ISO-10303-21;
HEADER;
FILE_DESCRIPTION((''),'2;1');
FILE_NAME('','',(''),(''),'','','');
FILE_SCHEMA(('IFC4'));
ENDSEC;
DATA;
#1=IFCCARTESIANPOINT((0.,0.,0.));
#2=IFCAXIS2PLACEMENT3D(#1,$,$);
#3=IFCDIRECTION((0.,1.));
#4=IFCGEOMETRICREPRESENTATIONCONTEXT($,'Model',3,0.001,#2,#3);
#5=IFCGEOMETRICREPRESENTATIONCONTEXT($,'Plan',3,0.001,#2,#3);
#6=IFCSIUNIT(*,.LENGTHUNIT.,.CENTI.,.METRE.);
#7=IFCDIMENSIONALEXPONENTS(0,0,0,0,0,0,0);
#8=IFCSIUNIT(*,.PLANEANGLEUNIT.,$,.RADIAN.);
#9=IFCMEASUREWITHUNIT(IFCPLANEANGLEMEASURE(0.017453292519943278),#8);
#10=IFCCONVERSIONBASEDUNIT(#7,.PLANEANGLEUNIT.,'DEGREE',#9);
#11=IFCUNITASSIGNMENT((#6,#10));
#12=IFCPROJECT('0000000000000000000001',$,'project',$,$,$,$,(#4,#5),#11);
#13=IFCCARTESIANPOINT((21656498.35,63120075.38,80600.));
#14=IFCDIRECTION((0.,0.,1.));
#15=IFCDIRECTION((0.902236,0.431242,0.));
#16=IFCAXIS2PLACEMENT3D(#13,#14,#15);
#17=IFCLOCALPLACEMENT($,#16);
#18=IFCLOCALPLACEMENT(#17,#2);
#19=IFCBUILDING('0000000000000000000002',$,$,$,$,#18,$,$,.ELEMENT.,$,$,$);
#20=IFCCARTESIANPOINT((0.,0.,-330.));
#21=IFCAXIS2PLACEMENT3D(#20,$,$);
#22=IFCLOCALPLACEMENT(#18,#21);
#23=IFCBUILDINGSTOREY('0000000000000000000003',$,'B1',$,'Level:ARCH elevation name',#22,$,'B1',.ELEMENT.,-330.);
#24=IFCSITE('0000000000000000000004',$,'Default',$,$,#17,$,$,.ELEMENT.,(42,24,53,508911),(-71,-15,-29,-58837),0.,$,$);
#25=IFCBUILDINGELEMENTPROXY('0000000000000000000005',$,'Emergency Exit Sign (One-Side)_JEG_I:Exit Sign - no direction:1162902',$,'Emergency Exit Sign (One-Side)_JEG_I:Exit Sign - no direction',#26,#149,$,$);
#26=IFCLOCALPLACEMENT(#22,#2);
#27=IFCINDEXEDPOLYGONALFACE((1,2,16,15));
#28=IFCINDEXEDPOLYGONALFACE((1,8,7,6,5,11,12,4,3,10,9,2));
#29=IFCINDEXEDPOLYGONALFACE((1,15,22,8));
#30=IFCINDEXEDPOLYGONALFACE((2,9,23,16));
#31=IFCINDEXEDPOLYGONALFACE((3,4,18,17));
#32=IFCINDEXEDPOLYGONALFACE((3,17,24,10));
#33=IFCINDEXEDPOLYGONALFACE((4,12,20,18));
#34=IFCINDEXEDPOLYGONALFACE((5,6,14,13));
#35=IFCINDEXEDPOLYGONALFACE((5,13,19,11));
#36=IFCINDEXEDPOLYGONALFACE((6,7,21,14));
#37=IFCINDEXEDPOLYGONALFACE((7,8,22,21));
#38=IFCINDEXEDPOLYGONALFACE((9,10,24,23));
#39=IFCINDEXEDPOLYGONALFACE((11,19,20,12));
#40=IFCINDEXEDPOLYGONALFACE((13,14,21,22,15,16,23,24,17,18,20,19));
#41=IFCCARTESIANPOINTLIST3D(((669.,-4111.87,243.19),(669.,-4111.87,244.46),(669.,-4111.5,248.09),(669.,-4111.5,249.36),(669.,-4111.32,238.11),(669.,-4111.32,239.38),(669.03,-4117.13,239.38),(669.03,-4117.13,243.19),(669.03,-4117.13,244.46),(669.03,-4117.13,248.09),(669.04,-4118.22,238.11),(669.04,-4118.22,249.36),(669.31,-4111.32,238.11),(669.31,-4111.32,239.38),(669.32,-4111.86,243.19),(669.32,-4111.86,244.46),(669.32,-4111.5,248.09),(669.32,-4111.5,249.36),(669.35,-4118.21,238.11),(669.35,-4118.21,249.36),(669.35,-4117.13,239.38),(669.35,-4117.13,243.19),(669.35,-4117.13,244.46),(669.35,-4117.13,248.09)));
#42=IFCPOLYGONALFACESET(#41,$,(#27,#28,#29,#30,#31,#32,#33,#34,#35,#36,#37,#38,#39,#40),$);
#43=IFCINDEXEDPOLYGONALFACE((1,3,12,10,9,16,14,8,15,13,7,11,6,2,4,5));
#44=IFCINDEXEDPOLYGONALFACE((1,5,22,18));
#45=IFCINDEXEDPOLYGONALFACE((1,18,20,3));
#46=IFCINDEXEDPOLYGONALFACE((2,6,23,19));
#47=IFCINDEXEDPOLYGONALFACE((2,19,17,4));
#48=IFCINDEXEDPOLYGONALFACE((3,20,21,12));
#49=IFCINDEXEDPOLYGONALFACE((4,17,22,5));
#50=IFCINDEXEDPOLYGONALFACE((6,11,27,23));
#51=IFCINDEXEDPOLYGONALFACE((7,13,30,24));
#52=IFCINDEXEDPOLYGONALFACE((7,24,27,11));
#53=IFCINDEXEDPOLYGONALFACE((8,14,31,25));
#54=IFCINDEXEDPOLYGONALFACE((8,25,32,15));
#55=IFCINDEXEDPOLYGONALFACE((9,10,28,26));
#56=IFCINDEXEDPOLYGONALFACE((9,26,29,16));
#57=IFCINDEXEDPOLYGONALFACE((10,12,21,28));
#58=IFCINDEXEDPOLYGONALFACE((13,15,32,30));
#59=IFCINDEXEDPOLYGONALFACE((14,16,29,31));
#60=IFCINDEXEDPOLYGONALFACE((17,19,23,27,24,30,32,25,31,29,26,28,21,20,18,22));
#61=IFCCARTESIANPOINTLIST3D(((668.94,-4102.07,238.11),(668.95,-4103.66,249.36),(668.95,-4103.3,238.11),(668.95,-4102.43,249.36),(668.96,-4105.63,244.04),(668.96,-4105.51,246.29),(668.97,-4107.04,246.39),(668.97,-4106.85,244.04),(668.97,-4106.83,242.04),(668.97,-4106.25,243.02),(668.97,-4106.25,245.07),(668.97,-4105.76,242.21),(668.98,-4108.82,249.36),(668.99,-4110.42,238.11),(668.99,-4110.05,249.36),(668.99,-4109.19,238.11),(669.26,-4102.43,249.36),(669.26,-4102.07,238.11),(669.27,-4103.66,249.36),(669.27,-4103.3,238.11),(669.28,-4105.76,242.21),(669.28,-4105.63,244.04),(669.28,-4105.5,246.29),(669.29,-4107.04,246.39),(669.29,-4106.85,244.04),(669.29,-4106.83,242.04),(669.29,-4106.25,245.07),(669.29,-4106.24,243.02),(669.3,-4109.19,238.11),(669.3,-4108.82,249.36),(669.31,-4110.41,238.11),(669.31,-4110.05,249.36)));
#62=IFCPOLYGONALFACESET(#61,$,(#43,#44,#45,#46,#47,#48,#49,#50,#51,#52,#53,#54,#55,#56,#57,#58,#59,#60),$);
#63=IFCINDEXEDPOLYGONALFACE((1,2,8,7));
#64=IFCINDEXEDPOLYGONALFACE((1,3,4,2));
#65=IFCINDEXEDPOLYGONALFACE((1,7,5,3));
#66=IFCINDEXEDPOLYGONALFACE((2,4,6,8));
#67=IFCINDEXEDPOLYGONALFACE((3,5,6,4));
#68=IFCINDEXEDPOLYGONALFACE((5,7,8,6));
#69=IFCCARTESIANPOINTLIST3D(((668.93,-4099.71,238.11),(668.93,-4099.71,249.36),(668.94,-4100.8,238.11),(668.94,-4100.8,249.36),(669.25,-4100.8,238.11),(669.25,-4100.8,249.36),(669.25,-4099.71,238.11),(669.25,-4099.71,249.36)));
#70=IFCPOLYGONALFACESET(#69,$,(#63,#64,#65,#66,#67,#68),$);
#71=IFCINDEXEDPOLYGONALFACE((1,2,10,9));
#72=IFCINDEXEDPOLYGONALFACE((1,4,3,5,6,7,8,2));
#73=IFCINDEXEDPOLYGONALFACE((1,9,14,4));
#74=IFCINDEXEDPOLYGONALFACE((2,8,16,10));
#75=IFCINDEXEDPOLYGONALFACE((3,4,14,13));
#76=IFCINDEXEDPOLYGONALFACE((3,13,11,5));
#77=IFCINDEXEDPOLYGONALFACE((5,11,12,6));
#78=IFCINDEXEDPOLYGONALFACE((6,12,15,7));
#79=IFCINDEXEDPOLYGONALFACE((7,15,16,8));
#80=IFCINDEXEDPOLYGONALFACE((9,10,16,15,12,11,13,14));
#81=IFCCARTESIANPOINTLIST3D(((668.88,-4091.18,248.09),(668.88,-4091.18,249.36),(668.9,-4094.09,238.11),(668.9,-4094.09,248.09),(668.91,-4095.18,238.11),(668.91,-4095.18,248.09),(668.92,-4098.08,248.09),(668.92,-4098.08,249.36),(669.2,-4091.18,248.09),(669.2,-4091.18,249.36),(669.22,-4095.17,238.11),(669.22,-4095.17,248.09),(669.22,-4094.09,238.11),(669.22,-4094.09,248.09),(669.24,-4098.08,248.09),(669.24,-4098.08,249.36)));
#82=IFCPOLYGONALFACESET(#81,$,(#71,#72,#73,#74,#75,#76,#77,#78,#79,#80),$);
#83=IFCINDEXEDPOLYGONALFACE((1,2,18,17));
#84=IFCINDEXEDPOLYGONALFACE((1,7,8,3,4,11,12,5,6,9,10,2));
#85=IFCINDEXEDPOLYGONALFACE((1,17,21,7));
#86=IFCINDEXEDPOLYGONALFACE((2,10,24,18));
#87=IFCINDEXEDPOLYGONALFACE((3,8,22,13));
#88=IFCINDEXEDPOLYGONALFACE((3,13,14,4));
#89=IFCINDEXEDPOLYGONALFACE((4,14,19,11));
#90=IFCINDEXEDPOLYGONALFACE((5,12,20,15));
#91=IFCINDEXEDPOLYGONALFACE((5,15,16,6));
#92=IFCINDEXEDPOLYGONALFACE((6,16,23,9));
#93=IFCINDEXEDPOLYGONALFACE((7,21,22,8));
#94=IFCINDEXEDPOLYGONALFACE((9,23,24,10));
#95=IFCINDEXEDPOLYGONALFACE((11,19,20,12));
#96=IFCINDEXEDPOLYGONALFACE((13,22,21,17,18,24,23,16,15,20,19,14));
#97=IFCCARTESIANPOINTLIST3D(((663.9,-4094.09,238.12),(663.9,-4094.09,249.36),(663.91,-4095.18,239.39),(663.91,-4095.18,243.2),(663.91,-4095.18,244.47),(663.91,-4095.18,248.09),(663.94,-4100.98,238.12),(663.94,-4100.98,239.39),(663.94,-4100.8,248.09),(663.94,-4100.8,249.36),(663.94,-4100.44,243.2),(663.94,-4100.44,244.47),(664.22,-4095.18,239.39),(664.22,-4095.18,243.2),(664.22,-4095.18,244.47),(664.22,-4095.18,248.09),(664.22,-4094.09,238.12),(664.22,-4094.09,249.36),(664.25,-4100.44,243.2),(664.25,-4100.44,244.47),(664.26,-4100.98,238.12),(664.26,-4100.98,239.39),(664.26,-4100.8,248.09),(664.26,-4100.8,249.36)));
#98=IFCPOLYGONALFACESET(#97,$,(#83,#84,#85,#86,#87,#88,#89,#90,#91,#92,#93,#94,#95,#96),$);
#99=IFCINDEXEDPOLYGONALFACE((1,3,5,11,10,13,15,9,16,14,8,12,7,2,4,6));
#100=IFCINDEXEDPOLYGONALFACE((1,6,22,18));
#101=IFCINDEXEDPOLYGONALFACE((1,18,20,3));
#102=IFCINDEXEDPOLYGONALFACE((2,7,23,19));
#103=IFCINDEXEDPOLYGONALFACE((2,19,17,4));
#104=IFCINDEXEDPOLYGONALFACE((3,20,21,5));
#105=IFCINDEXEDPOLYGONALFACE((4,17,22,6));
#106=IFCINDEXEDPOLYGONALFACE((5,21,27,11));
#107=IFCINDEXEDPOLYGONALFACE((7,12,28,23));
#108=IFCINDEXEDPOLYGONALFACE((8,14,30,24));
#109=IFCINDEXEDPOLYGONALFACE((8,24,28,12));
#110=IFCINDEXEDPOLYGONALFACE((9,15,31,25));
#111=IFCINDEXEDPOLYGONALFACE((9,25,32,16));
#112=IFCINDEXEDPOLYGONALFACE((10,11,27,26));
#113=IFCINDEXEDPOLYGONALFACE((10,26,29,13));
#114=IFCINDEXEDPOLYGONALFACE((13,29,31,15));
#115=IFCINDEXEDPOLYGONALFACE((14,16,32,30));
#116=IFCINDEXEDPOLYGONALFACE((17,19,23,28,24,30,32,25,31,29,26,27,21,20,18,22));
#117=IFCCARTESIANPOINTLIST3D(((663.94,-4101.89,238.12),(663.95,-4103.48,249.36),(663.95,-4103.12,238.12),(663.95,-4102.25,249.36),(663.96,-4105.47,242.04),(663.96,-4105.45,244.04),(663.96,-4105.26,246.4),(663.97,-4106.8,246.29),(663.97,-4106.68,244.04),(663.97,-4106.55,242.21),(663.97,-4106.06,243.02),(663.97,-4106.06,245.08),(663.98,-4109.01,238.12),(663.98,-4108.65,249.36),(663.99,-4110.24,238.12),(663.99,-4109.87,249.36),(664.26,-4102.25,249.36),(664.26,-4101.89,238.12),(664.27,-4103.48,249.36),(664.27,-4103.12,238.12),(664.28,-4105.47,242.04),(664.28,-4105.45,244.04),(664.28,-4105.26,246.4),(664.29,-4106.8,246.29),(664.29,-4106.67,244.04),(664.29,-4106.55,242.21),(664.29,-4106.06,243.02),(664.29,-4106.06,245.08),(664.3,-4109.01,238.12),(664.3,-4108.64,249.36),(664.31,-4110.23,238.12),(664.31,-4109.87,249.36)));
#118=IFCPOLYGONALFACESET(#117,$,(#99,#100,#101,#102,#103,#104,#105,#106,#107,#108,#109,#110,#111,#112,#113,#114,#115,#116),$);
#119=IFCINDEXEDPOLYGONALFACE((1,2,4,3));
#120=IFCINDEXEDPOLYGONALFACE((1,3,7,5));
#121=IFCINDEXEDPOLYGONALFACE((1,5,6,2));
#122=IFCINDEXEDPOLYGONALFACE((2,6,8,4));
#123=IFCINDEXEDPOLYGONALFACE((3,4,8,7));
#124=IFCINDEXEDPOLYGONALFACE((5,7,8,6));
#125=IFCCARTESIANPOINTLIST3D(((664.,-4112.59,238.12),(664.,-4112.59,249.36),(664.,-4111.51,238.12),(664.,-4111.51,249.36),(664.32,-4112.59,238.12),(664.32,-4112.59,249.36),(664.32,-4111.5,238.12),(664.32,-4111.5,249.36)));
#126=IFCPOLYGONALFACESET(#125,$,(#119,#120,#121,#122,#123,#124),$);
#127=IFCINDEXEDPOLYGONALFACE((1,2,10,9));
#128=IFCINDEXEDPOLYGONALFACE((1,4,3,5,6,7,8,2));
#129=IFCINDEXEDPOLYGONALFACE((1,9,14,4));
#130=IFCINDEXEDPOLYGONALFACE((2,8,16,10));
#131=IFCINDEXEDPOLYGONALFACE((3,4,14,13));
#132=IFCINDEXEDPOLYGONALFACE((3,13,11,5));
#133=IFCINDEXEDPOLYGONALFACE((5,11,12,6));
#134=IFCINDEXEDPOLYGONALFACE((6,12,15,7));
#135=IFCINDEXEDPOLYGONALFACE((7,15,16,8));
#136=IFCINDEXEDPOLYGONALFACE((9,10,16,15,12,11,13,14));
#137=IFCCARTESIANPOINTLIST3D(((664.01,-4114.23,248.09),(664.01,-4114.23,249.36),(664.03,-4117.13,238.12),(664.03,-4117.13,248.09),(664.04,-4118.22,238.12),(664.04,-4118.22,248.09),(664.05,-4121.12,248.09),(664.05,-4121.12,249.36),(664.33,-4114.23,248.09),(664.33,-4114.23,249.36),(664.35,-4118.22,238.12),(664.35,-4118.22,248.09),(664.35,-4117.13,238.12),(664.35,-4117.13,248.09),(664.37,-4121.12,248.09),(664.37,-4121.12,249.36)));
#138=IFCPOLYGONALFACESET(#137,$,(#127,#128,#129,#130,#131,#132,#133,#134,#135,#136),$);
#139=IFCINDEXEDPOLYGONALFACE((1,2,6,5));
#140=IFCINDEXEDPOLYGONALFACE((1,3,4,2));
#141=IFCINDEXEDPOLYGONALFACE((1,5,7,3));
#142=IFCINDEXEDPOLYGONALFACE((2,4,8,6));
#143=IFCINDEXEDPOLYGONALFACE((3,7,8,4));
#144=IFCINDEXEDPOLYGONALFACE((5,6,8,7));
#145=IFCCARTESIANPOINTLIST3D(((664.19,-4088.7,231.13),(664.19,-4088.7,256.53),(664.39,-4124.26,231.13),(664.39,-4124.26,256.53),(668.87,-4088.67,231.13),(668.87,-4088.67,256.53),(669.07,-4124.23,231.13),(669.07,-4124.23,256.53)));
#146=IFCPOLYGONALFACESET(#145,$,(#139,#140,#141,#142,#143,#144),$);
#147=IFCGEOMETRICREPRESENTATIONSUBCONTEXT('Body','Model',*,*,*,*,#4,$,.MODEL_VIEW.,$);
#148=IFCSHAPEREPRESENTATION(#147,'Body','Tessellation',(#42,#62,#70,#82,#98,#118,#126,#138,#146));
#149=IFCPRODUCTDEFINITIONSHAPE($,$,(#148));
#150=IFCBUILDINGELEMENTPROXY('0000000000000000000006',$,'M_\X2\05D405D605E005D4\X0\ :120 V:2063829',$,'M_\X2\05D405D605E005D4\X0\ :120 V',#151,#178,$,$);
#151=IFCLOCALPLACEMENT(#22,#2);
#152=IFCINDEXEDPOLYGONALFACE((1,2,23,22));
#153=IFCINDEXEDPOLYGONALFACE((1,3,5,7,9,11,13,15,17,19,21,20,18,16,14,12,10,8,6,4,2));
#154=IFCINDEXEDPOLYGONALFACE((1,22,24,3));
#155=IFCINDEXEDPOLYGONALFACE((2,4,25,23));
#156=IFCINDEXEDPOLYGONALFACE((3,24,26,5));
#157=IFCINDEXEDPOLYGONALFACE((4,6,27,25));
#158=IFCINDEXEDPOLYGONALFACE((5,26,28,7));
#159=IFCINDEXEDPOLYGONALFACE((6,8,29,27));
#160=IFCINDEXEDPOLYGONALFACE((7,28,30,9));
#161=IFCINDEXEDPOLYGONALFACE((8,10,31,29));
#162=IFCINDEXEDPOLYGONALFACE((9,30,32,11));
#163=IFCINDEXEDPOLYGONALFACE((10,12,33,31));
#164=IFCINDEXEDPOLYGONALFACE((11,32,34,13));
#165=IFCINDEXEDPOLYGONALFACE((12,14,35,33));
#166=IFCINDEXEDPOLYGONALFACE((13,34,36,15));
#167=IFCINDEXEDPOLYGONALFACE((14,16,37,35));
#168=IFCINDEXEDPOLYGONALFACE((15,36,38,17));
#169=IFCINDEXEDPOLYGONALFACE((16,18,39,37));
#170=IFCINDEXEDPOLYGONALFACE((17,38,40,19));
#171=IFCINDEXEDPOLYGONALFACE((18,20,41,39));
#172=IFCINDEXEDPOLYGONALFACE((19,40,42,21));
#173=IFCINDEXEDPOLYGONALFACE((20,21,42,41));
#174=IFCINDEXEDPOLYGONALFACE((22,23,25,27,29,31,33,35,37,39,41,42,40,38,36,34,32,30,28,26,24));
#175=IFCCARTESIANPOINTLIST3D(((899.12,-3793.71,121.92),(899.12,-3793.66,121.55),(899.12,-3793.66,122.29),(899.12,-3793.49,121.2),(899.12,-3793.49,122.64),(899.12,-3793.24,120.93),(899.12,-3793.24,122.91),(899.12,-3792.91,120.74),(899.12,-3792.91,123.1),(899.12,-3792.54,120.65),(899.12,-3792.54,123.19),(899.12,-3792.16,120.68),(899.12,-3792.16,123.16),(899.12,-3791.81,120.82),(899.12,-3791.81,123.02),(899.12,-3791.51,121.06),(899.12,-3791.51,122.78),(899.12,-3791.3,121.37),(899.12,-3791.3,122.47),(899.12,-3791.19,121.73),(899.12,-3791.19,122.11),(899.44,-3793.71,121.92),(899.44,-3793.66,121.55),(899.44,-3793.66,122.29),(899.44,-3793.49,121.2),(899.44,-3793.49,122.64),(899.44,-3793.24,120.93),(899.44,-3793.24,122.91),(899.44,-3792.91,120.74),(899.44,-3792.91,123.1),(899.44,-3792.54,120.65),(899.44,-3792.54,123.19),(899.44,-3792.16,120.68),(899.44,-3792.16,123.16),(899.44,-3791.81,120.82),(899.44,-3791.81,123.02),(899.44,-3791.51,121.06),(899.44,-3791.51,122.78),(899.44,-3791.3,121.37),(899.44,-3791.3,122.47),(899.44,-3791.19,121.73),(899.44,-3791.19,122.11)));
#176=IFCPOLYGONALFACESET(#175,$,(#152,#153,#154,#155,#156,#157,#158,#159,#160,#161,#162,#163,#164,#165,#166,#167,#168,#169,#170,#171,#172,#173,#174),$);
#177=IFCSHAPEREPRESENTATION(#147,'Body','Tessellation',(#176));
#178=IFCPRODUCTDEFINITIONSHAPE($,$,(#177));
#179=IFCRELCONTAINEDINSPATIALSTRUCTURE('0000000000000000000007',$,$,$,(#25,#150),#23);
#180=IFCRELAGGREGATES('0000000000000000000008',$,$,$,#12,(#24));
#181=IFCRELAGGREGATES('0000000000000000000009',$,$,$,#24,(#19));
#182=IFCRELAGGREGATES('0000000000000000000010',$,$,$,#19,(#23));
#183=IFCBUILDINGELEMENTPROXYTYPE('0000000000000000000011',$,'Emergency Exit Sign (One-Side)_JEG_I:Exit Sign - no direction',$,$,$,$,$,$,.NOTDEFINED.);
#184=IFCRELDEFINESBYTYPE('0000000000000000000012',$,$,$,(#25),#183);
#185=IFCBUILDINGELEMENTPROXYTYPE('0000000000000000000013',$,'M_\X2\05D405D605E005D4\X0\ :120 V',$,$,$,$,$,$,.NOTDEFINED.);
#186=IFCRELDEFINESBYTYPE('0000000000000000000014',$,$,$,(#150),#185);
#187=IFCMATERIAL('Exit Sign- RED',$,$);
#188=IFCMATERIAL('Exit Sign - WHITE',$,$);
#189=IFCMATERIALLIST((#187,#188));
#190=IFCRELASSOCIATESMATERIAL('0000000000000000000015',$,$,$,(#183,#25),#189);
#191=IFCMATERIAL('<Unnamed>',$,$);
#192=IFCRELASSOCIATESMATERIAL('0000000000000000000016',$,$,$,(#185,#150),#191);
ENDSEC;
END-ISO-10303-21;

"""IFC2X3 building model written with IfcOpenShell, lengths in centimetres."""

from ifc_helpers import new_model, entity, si_unit, converted_unit, direction, frame, frame_2d, origin, origin_2d_with_axis, place, context, subcontext, project, spatial, polyline, rectangle, circle, outline, extrude, source, transform, mapped, material, material_list, type_object, type_shapes, element, save


model = new_model("IFC2X3")

# Units and contexts
model_context = context("Model", 3, precision=0.001, world=origin(), true_north=direction((0.0, 1.0)))
plan_context = context("Plan", 3, precision=0.001, world=origin(), true_north=direction((0.0, 1.0)))
body_context = subcontext(model_context, "Body", "Model", "MODEL_VIEW")
ifc_project = project(units=[si_unit("LENGTHUNIT", "METRE", prefix="CENTI"), converted_unit("PLANEANGLEUNIT", "DEGREE", entity("IfcPlaneAngleMeasure", 0.017453292519943278), si_unit("PLANEANGLEUNIT", "RADIAN"), dimensions=[0, 0, 0, 0, 0, 0, 0])], contexts=[model_context, plan_context])

# Site, building, storey
site_placement = place(None, frame((21656498.35, 63120075.38, 80600.0), z_axis=(0.0, 0.0, 1.0), x_axis=(0.902236, 0.431242, 0.0)))
site = spatial("IfcSite", under=ifc_project, at=site_placement, Name="Default", CompositionType="ELEMENT", RefLatitude=(42, 24, 53, 508911), RefLongitude=(-71, -15, -29, -58837), RefElevation=0.0)
building_placement = place(site_placement, origin())
building = spatial("IfcBuilding", under=site, at=building_placement, CompositionType="ELEMENT")
storey_placement = place(building_placement, frame((0.0, 0.0, -330.0)))
storey = spatial("IfcBuildingStorey", under=building, at=storey_placement, Name="B1", ObjectType="Level:ARCH elevation name", LongName="B1", CompositionType="ELEMENT", Elevation=-330.0)

# Building element proxies
ifc_material_1 = material(Name="Exit Sign- RED")
ifc_material_2 = material(Name="Exit Sign - WHITE")
ifc_material_list = material_list([ifc_material_1, ifc_material_2])
building_element_proxy_type_1 = type_object("IfcBuildingElementProxyType", Name="Emergency Exit Sign (One-Side)_JEG_I:Exit Sign - no direction", PredefinedType="NOTDEFINED", material=ifc_material_list)
shared_shape_1 = source(origin(), body_context, "Body", "SweptSolid", [
    extrude(outline(polyline([(-5.65, -3.69), (5.59, -3.69), (5.59, 3.02), (4.32, 3.02), (4.32, -2.6), (0.7, -2.6), (0.7, 2.66), (-0.57, 2.66), (-0.57, -2.6), (-4.38, -2.6), (-4.38, 3.21), (-5.65, 3.21), (-5.65, -3.69)])), frame((-8.08, -5.22, 12.64), z_axis=(0.0, 1.0, 0.0), x_axis=(0.0, 0.0, 1.0)), (0.0, 0.0, 1.0), 0.32),
    extrude(outline(polyline([(-7.14, 0.57), (-6.5, -0.49), (-1.93, -0.48), (-0.78, -0.48), (-1.23, -1.32), (-3.47, -5.53), (-2.84, -6.59), (0.41, -0.48), (6.62, -0.48), (5.99, 0.57), (2.4, 0.57), (0.98, 0.58), (1.7, 1.94), (3.32, 5.0), (2.69, 6.05), (-0.22, 0.57), (-7.14, 0.57)])), frame((0.2, -5.22, 12.81), z_axis=(0.0, -1.0, 0.0), x_axis=(0.515099, 0.0, 0.857131)), (0.0, 0.0, -1.0), 0.32),
    extrude(rectangle(XDim=0.32, YDim=1.09, at=frame_2d((0.0, 0.0), x_axis=(1.0, 0.0))), frame((6.19, -5.06, 6.99), z_axis=(0.0, 0.0, 1.0), x_axis=(0.0, 1.0, 0.0)), (0.0, 0.0, 1.0), 11.25),
    extrude(outline(polyline([(-7.8, 0.54), (-7.8, -0.54), (2.18, -0.54), (2.18, -3.45), (3.45, -3.45), (3.45, 3.45), (2.18, 3.45), (2.18, 0.54), (-7.8, 0.54)])), frame((11.82, -5.22, 14.79), z_axis=(0.0, -1.0, 0.0), x_axis=(0.0, 0.0, 1.0)), (0.0, 0.0, -1.0), 0.32),
    extrude(outline(polyline([(-3.69, -5.65), (3.21, -5.65), (3.21, -4.38), (-2.6, -4.38), (-2.6, -0.57), (2.66, -0.57), (2.66, 0.7), (-2.6, 0.7), (-2.6, 4.32), (3.02, 4.32), (3.02, 5.59), (-3.69, 5.59), (-3.69, -5.65)])), frame((8.7, -0.22, 12.65), z_axis=(0.0, 1.0, 0.0), x_axis=(-1.0, 0.0, 0.0)), (0.0, 0.0, 1.0), 0.32),
    extrude(outline(polyline([(-4.16, -5.82), (-2.93, -5.82), (-0.58, -1.9), (0.01, -0.92), (0.5, -1.73), (2.96, -5.82), (4.18, -5.82), (0.62, 0.1), (3.82, 5.42), (2.59, 5.42), (0.75, 2.35), (0.01, 1.14), (-0.79, 2.46), (-2.57, 5.42), (-3.8, 5.42), (-0.6, 0.1), (-4.16, -5.82)])), frame((0.43, -0.22, 12.82), z_axis=(0.0, 1.0, 0.0), x_axis=(-1.0, 0.0, 0.0)), (0.0, 0.0, 1.0), 0.32),
    extrude(rectangle(XDim=0.32, YDim=1.09, at=origin_2d_with_axis()), frame((-5.57, -0.06, 6.99), z_axis=(0.0, 0.0, 1.0), x_axis=(0.0, -1.0, 0.0)), (0.0, 0.0, 1.0), 11.25),
    extrude(outline(polyline([(-0.54, -7.8), (0.54, -7.8), (0.54, 2.18), (3.45, 2.18), (3.45, 3.45), (-3.45, 3.45), (-3.45, 2.18), (-0.54, 2.18), (-0.54, -7.8)])), frame((-11.2, -0.22, 14.79), z_axis=(0.0, 1.0, 0.0), x_axis=(-1.0, 0.0, 0.0)), (0.0, 0.0, 1.0), 0.32),
    extrude(rectangle(XDim=4.68, YDim=35.56, at=origin_2d_with_axis()), frame((0.0, -2.56, 0.01), z_axis=(0.0, 0.0, 1.0), x_axis=(0.0, 1.0, 0.0)), (0.0, 0.0, 1.0), 25.4),
])
type_shapes(building_element_proxy_type_1, [shared_shape_1])
proxy_1_placement = place(storey_placement, frame((664.07, -4106.48, 231.12), z_axis=(0.0, 0.0, 1.0), x_axis=(-0.005676, 0.999984, 0.0)))
element("IfcBuildingElementProxy", 1, at=proxy_1_placement, inside=storey, type_object=building_element_proxy_type_1, material=ifc_material_list, Name="Emergency Exit Sign (One-Side)_JEG_I:Exit Sign - no direction:1162902", ObjectType="Emergency Exit Sign (One-Side)_JEG_I:Exit Sign - no direction", context=body_context, shape_type="MappedRepresentation", body=[
    mapped(shared_shape_1, transform((0.0, 0.0, 0.0), scale=1.0)),
])
ifc_material_3 = material(Name="<Unnamed>")
building_element_proxy_type_2 = type_object("IfcBuildingElementProxyType", Name="M_הזנה :120 V", PredefinedType="NOTDEFINED", material=ifc_material_3)
shared_shape_2 = source(origin(), body_context, "Body", "SweptSolid", [
    extrude(circle(Radius=1.27, at=frame_2d((0.0, 0.0), x_axis=(1.0, 0.0))), origin(), (0.0, 0.0, 1.0), 0.32),
])
type_shapes(building_element_proxy_type_2, [shared_shape_2])
for number, where, z_axis, x_axis, name in (
    (2, (899.44, -3792.44, 121.92), (-1.0, 0.0, 0.0), (0.0, -1.0, 0.0), "M_הזנה :120 V:2063829"),
):
    element("IfcBuildingElementProxy", number, at=place(storey_placement, frame(where, z_axis=z_axis, x_axis=x_axis)), inside=storey, type_object=building_element_proxy_type_2, material=ifc_material_3, Name=name, ObjectType="M_הזנה :120 V", context=body_context, shape_type="MappedRepresentation", body=[
        mapped(shared_shape_2, transform((0.0, 0.0, 0.0), scale=1.0)),
    ])

save(model, "model.ifc")
